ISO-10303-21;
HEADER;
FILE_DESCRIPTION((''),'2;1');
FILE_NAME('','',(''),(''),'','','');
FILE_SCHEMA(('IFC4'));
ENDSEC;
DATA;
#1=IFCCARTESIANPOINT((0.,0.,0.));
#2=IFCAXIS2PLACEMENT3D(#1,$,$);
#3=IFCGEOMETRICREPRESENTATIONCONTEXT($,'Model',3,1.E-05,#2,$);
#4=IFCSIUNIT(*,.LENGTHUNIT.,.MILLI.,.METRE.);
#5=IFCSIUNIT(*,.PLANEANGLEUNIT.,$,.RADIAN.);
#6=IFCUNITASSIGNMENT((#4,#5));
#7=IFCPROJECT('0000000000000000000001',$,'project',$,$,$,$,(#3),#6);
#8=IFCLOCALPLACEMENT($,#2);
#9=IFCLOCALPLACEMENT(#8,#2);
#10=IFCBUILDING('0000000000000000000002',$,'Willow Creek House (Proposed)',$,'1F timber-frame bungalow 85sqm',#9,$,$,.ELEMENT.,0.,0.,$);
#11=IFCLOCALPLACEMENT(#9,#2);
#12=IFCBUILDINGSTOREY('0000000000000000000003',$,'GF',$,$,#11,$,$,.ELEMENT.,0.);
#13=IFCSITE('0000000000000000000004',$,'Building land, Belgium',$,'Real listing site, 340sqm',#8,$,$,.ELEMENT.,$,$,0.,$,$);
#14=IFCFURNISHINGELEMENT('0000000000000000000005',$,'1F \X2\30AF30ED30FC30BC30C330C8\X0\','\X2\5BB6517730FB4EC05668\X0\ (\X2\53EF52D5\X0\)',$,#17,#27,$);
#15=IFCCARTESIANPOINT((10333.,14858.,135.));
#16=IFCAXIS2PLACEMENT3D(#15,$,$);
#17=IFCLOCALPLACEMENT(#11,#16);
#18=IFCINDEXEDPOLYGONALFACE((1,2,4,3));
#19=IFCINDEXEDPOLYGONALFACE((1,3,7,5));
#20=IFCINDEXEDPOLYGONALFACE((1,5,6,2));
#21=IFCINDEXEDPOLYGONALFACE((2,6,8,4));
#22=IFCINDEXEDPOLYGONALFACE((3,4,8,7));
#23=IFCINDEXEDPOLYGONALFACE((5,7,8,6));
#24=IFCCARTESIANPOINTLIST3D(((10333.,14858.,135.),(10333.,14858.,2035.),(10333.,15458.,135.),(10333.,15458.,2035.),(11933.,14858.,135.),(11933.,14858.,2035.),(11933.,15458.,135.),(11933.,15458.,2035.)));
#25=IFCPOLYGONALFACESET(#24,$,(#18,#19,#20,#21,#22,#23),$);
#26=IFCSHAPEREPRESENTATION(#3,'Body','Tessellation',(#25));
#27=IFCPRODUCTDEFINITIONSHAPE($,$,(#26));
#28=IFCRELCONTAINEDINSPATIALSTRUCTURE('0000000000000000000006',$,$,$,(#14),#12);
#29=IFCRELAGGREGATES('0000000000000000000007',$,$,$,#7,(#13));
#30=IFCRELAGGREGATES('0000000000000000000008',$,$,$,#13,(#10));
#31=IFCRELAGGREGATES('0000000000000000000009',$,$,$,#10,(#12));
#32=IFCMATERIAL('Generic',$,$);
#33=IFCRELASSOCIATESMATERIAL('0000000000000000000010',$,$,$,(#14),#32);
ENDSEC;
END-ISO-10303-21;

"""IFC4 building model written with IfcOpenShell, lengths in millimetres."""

from ifc_helpers import new_model, si_unit, frame, frame_2d, origin, place, context, project, spatial, rectangle, extrude, material, element, save


model = new_model("IFC4")

# Units and contexts
model_context = context("Model", 3, precision=1e-05, world=origin())
ifc_project = project(units=[si_unit("LENGTHUNIT", "METRE", prefix="MILLI"), si_unit("PLANEANGLEUNIT", "RADIAN")], contexts=[model_context])

# Site, building, storey
site_placement = place(None, origin())
site = spatial("IfcSite", under=ifc_project, at=site_placement, Name="Building land, Belgium", ObjectType="Real listing site, 340sqm", CompositionType="ELEMENT", RefElevation=0.0)
building_placement = place(site_placement, origin())
building = spatial("IfcBuilding", under=site, at=building_placement, Name="Willow Creek House (Proposed)", ObjectType="1F timber-frame bungalow 85sqm", CompositionType="ELEMENT", ElevationOfRefHeight=0.0, ElevationOfTerrain=0.0)
storey_placement = place(building_placement, origin())
storey = spatial("IfcBuildingStorey", under=building, at=storey_placement, Name="GF", CompositionType="ELEMENT", Elevation=0.0)

# Shared definitions
ifc_material_1 = material(Name="Generic")

# Furnishing element
furnishing_placement = place(storey_placement, frame((10333.0, 14858.0, 135.0)))
element("IfcFurnishingElement", 1, at=furnishing_placement, inside=storey, material=ifc_material_1, Name="1F クローゼット", Description="家具・什器 (可動)", context=model_context, shape_type="SweptSolid", body=[
    extrude(rectangle(XDim=1600.0, YDim=600.0, at=frame_2d((800.0, 300.0))), frame((10333.0, 14858.0, 135.0)), (0.0, 0.0, 1.0), 1900.0),
])

save(model, "model.ifc")
